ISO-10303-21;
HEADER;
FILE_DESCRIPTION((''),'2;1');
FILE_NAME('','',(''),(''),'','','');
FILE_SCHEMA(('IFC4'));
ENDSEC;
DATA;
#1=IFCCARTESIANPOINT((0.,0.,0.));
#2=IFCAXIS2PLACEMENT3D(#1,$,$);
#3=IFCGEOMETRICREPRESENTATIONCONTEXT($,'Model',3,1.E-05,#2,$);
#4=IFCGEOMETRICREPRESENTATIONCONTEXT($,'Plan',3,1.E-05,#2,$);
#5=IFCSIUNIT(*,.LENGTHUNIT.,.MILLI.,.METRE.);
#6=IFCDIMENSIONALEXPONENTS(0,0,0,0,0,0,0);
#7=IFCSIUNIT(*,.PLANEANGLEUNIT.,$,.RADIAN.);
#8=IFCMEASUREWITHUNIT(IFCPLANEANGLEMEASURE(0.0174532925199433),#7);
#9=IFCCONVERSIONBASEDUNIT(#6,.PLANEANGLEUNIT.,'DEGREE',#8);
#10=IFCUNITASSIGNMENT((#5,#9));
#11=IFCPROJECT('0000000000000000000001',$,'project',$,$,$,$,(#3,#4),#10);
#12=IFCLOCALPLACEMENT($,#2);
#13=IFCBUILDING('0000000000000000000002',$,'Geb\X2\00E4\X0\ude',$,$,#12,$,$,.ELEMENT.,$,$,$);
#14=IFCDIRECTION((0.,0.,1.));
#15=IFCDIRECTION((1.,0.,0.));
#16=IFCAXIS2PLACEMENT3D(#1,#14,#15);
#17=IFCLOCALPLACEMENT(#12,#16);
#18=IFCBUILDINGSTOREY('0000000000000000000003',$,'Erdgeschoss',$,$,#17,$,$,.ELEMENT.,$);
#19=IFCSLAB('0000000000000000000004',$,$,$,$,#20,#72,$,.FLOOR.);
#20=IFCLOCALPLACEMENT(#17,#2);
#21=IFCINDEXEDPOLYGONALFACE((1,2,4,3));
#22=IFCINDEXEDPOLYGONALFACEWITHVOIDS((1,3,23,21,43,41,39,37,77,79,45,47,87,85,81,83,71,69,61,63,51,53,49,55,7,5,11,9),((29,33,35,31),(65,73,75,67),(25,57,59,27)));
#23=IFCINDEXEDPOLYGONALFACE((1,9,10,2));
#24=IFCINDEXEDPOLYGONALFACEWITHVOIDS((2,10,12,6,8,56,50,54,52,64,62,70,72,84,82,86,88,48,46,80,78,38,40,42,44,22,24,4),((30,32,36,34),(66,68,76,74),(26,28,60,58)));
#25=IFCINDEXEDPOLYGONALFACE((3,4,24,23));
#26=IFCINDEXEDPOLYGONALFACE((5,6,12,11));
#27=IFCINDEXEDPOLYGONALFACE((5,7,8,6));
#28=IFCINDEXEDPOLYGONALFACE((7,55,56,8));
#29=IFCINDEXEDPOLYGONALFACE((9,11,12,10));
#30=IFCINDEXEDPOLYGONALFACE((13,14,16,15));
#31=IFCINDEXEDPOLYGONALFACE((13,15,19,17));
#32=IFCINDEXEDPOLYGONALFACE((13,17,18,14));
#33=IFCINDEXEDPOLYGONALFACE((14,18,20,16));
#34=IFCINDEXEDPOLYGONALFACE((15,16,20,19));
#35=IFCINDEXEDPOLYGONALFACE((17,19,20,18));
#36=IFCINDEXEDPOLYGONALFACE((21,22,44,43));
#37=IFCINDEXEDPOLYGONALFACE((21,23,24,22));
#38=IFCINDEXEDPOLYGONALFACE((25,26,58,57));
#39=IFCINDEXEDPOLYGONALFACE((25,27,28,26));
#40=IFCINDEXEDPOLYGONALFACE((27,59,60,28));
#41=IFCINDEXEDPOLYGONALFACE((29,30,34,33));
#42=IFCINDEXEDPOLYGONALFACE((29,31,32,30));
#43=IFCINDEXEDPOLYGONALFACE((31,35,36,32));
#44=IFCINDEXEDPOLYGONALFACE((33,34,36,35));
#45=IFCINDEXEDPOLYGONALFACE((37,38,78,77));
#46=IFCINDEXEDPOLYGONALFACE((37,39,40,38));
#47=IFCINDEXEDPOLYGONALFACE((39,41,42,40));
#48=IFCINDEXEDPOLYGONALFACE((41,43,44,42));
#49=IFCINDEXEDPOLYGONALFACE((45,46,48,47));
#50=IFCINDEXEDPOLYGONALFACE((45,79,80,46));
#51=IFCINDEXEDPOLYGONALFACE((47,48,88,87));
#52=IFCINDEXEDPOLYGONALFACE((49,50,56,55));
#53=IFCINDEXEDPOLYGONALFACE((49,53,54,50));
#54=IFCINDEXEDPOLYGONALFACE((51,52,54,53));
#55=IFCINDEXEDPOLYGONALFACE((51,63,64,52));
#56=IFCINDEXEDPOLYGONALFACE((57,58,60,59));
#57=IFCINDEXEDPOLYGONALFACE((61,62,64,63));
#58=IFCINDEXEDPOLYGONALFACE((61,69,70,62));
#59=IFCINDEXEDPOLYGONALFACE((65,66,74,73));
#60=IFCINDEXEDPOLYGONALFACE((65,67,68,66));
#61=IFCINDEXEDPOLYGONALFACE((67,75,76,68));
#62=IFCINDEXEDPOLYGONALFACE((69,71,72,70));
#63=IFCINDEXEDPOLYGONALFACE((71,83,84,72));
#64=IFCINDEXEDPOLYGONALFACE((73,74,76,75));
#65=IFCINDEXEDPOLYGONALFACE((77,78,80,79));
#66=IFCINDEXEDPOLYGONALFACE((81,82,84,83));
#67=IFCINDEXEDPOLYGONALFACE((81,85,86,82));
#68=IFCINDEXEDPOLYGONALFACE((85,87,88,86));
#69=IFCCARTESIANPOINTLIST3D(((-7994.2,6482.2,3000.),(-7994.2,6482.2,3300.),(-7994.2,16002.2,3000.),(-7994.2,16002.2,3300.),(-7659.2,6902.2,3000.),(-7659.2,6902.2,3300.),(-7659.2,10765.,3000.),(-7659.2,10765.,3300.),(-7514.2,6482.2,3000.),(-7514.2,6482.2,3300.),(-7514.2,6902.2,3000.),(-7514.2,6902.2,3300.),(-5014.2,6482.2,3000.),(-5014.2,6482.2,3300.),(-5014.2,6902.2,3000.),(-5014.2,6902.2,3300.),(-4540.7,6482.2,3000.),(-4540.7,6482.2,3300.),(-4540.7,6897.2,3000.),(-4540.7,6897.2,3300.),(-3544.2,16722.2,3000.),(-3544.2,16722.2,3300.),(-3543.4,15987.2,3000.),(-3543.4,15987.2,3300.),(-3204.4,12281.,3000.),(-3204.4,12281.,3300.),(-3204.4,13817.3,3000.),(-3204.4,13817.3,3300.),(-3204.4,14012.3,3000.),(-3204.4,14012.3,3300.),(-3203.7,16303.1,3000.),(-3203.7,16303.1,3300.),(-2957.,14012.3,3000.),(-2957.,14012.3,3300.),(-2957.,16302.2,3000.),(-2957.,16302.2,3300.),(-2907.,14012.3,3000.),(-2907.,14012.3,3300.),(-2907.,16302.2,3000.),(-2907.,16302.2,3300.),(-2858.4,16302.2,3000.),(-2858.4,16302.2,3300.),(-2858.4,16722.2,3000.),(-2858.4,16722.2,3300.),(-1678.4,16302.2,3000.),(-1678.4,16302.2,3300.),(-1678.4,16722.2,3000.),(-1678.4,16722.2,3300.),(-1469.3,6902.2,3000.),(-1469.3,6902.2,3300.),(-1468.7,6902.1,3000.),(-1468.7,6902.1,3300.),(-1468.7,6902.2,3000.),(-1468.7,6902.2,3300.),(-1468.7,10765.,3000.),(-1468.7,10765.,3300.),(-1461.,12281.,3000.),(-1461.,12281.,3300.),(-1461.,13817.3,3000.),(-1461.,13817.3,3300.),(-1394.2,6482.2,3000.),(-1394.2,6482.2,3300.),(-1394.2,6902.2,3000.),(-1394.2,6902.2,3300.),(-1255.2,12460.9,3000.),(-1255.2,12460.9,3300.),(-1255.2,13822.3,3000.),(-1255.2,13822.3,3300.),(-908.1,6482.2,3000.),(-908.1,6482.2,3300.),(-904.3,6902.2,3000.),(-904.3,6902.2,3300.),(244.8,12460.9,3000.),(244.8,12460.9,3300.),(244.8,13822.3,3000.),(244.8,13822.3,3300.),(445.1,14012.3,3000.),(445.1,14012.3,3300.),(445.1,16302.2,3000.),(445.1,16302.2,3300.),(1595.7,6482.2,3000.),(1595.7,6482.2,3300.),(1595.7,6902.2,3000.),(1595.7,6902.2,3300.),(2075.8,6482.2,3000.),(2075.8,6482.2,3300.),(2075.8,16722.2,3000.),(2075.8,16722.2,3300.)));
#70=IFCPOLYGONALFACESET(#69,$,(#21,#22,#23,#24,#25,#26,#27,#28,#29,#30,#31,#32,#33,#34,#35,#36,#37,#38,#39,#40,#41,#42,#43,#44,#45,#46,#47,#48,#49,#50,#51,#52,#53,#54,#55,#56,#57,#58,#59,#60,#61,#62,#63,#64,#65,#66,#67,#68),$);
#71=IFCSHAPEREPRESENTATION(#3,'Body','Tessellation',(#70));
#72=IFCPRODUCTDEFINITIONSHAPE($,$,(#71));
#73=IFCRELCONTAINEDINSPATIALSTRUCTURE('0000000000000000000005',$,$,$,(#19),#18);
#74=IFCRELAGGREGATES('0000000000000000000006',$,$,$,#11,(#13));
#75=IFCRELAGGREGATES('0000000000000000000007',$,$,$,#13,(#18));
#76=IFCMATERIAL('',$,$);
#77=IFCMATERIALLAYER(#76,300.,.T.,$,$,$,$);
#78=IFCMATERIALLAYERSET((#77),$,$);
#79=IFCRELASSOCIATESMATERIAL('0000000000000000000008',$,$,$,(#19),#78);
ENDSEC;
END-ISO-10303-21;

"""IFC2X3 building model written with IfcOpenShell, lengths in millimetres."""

from ifc_helpers import new_model, entity, si_unit, converted_unit, frame, frame_2d, origin, origin_with_axes, place, context, project, spatial, polyline, rectangle, outline, extrude, material, layer, layer_set, layer_usage, element, save


model = new_model("IFC2X3")

# Units and contexts
model_context = context("Model", 3, precision=1e-05, world=origin())
plan_context = context("Plan", 3, precision=1e-05, world=origin())
ifc_project = project(units=[si_unit("LENGTHUNIT", "METRE", prefix="MILLI"), converted_unit("PLANEANGLEUNIT", "DEGREE", entity("IfcPlaneAngleMeasure", 0.0174532925199433), si_unit("PLANEANGLEUNIT", "RADIAN"), dimensions=[0, 0, 0, 0, 0, 0, 0])], contexts=[model_context, plan_context])

# Building, storey
building_placement = place(None, origin())
building = spatial("IfcBuilding", under=ifc_project, at=building_placement, Name="Gebäude", CompositionType="ELEMENT")
storey_placement = place(building_placement, origin_with_axes())
storey = spatial("IfcBuildingStorey", under=building, at=storey_placement, Name="Erdgeschoss", CompositionType="ELEMENT")

# Slab, openings
ifc_material = material(Name="")
ifc_layer = layer(ifc_material, 300.0, ventilated=True)
ifc_layer_set = layer_set([ifc_layer])
ifc_layer_usage = layer_usage(ifc_layer_set, "AXIS3", "POSITIVE", 0.0)
slab_placement = place(storey_placement, frame((-7994.2, 6482.2, 3000.0), z_axis=(0.0, 0.0, 1.0), x_axis=(1.0, 0.0, 0.0)))
slab = element("IfcSlab", 1, at=slab_placement, inside=storey, material=ifc_layer_usage, PredefinedType="FLOOR", context=model_context, shape_type="SweptSolid", body=[
    extrude(outline(polyline([(0.0, 9520.0), (0.0, 0.0), (10070.0, 0.0), (10070.0, 10240.0), (4450.0, 10240.0), (4450.9, 9504.9), (0.0, 9520.0)])), origin_with_axes(), (0.0, 0.0, 1.0), 300.0),
])
opening_1_placement = place(slab_placement, frame((5135.9, 10240.0, 0.0), z_axis=(0.0, 0.0, 1.0), x_axis=(1.0, 0.0, 0.0)))
element("IfcOpeningElement", 2, at=opening_1_placement, cuts=slab, ObjectType="Opening", context=model_context, shape_type="SweptSolid", body=[
    extrude(rectangle(XDim=420.0, YDim=1180.0, at=frame_2d((590.0, -210.0), x_axis=(0.0, -1.0))), origin_with_axes(), (0.0, 0.0, 1.0), 300.0),
])
opening_2_placement = place(slab_placement, frame((335.0, 415.0, 0.0), z_axis=(0.0, 0.0, 1.0), x_axis=(1.0, 0.0, 0.0)))
element("IfcOpeningElement", 3, at=opening_2_placement, cuts=slab, ObjectType="Opening", context=model_context, shape_type="SweptSolid", body=[
    extrude(outline(polyline([(3118.5, 0.0), (6190.0, 5.0), (6190.5, 3867.7), (0.0, 3867.7), (0.0, 5.0), (2645.0, 5.0), (3118.5, 0.0)])), origin_with_axes(), (0.0, 0.0, 1.0), 300.0),
])
opening_3_placement = place(slab_placement, frame((5087.2, 7530.1, 0.0), z_axis=(0.0, 0.0, 1.0), x_axis=(1.0, 0.0, 0.0)))
element("IfcOpeningElement", 4, at=opening_3_placement, cuts=slab, ObjectType="Opening", context=model_context, shape_type="SweptSolid", body=[
    extrude(rectangle(XDim=3352.1, YDim=2289.9, at=frame_2d((1676.0, 1144.9), x_axis=(1.0, 0.0))), origin_with_axes(), (0.0, 0.0, 1.0), 300.0),
])
opening_4_placement = place(slab_placement, frame((480.0, 0.0, 0.0), z_axis=(0.0, 0.0, 1.0), x_axis=(1.0, 0.0, 0.0)))
element("IfcOpeningElement", 5, at=opening_4_placement, cuts=slab, ObjectType="Opening", context=model_context, shape_type="SweptSolid", body=[
    extrude(rectangle(XDim=2500.0, YDim=420.0, at=frame_2d((1250.0, 210.0), x_axis=(1.0, 0.0))), origin_with_axes(), (0.0, 0.0, 1.0), 300.0),
])
opening_5_placement = place(slab_placement, frame((7086.1, 0.0, 0.0), z_axis=(0.0, 0.0, 1.0), x_axis=(1.0, 0.0, 0.0)))
element("IfcOpeningElement", 6, at=opening_5_placement, cuts=slab, ObjectType="Opening", context=model_context, shape_type="SweptSolid", body=[
    extrude(outline(polyline([(0.0, 0.0), (2503.9, 0.0), (2503.9, 420.0), (3.9, 420.0), (0.0, 0.0)])), origin_with_axes(), (0.0, 0.0, 1.0), 300.0),
])
opening_6_placement = place(slab_placement, frame((6739.1, 5978.7, 0.0), z_axis=(0.0, 0.0, 1.0), x_axis=(1.0, 0.0, 0.0)))
element("IfcOpeningElement", 7, at=opening_6_placement, cuts=slab, ObjectType="Opening", context=model_context, shape_type="SweptSolid", body=[
    extrude(rectangle(XDim=1500.0, YDim=1361.4, at=frame_2d((750.0, 680.7), x_axis=(1.0, 0.0))), origin_with_axes(), (0.0, 0.0, 1.0), 300.0),
])
opening_7_placement = place(slab_placement, frame((3453.5, 0.0, 0.0), z_axis=(0.0, 0.0, 1.0), x_axis=(1.0, 0.0, 0.0)))
element("IfcOpeningElement", 8, at=opening_7_placement, cuts=slab, ObjectType="Opening", context=model_context, shape_type="SweptSolid", body=[
    extrude(outline(polyline([(0.0, 0.0), (3146.5, 0.0), (3072.0, 420.0), (0.0, 415.0), (0.0, 0.0)])), origin_with_axes(), (0.0, 0.0, 1.0), 300.0),
])
opening_8_placement = place(slab_placement, frame((7090.0, 0.0, 0.0), z_axis=(0.0, 0.0, 1.0), x_axis=(1.0, 0.0, 0.0)))
element("IfcOpeningElement", 9, at=opening_8_placement, cuts=slab, ObjectType="Opening", context=model_context, shape_type="SweptSolid", body=[
    extrude(rectangle(XDim=2500.0, YDim=420.0, at=frame_2d((1250.0, 210.0), x_axis=(1.0, 0.0))), origin_with_axes(), (0.0, 0.0, 1.0), 300.0),
])
opening_9_placement = place(slab_placement, frame((4789.8, 7530.1, 0.0), z_axis=(0.0, 0.0, 1.0), x_axis=(1.0, 0.0, 0.0)))
element("IfcOpeningElement", 10, at=opening_9_placement, cuts=slab, ObjectType="Opening", context=model_context, shape_type="SweptSolid", body=[
    extrude(outline(polyline([(0.7, 2290.7), (0.0, 0.0), (247.4, 0.0), (247.4, 2289.9), (0.7, 2290.7)])), origin_with_axes(), (0.0, 0.0, 1.0), 300.0),
])
opening_10_placement = place(slab_placement, frame((3453.5, 0.0, 0.0), z_axis=(0.0, 0.0, 1.0), x_axis=(1.0, 0.0, 0.0)))
element("IfcOpeningElement", 11, at=opening_10_placement, cuts=slab, ObjectType="Opening", context=model_context, shape_type="SweptSolid", body=[
    extrude(outline(polyline([(0.0, 0.0), (3146.5, 0.0), (3146.5, 420.0), (0.0, 415.0), (0.0, 0.0)])), origin_with_axes(), (0.0, 0.0, 1.0), 300.0),
])
opening_11_placement = place(slab_placement, frame((4789.8, 7335.1, 0.0), z_axis=(0.0, 0.0, 1.0), x_axis=(1.0, 0.0, 0.0)))
element("IfcOpeningElement", 12, at=opening_11_placement, cuts=slab, ObjectType="Opening", context=model_context, shape_type="SweptSolid", body=[
    extrude(rectangle(XDim=1536.4, YDim=1743.4, at=frame_2d((871.7, -768.2), x_axis=(0.0, -1.0))), origin_with_axes(), (0.0, 0.0, 1.0), 300.0),
])

save(model, "model.ifc")
